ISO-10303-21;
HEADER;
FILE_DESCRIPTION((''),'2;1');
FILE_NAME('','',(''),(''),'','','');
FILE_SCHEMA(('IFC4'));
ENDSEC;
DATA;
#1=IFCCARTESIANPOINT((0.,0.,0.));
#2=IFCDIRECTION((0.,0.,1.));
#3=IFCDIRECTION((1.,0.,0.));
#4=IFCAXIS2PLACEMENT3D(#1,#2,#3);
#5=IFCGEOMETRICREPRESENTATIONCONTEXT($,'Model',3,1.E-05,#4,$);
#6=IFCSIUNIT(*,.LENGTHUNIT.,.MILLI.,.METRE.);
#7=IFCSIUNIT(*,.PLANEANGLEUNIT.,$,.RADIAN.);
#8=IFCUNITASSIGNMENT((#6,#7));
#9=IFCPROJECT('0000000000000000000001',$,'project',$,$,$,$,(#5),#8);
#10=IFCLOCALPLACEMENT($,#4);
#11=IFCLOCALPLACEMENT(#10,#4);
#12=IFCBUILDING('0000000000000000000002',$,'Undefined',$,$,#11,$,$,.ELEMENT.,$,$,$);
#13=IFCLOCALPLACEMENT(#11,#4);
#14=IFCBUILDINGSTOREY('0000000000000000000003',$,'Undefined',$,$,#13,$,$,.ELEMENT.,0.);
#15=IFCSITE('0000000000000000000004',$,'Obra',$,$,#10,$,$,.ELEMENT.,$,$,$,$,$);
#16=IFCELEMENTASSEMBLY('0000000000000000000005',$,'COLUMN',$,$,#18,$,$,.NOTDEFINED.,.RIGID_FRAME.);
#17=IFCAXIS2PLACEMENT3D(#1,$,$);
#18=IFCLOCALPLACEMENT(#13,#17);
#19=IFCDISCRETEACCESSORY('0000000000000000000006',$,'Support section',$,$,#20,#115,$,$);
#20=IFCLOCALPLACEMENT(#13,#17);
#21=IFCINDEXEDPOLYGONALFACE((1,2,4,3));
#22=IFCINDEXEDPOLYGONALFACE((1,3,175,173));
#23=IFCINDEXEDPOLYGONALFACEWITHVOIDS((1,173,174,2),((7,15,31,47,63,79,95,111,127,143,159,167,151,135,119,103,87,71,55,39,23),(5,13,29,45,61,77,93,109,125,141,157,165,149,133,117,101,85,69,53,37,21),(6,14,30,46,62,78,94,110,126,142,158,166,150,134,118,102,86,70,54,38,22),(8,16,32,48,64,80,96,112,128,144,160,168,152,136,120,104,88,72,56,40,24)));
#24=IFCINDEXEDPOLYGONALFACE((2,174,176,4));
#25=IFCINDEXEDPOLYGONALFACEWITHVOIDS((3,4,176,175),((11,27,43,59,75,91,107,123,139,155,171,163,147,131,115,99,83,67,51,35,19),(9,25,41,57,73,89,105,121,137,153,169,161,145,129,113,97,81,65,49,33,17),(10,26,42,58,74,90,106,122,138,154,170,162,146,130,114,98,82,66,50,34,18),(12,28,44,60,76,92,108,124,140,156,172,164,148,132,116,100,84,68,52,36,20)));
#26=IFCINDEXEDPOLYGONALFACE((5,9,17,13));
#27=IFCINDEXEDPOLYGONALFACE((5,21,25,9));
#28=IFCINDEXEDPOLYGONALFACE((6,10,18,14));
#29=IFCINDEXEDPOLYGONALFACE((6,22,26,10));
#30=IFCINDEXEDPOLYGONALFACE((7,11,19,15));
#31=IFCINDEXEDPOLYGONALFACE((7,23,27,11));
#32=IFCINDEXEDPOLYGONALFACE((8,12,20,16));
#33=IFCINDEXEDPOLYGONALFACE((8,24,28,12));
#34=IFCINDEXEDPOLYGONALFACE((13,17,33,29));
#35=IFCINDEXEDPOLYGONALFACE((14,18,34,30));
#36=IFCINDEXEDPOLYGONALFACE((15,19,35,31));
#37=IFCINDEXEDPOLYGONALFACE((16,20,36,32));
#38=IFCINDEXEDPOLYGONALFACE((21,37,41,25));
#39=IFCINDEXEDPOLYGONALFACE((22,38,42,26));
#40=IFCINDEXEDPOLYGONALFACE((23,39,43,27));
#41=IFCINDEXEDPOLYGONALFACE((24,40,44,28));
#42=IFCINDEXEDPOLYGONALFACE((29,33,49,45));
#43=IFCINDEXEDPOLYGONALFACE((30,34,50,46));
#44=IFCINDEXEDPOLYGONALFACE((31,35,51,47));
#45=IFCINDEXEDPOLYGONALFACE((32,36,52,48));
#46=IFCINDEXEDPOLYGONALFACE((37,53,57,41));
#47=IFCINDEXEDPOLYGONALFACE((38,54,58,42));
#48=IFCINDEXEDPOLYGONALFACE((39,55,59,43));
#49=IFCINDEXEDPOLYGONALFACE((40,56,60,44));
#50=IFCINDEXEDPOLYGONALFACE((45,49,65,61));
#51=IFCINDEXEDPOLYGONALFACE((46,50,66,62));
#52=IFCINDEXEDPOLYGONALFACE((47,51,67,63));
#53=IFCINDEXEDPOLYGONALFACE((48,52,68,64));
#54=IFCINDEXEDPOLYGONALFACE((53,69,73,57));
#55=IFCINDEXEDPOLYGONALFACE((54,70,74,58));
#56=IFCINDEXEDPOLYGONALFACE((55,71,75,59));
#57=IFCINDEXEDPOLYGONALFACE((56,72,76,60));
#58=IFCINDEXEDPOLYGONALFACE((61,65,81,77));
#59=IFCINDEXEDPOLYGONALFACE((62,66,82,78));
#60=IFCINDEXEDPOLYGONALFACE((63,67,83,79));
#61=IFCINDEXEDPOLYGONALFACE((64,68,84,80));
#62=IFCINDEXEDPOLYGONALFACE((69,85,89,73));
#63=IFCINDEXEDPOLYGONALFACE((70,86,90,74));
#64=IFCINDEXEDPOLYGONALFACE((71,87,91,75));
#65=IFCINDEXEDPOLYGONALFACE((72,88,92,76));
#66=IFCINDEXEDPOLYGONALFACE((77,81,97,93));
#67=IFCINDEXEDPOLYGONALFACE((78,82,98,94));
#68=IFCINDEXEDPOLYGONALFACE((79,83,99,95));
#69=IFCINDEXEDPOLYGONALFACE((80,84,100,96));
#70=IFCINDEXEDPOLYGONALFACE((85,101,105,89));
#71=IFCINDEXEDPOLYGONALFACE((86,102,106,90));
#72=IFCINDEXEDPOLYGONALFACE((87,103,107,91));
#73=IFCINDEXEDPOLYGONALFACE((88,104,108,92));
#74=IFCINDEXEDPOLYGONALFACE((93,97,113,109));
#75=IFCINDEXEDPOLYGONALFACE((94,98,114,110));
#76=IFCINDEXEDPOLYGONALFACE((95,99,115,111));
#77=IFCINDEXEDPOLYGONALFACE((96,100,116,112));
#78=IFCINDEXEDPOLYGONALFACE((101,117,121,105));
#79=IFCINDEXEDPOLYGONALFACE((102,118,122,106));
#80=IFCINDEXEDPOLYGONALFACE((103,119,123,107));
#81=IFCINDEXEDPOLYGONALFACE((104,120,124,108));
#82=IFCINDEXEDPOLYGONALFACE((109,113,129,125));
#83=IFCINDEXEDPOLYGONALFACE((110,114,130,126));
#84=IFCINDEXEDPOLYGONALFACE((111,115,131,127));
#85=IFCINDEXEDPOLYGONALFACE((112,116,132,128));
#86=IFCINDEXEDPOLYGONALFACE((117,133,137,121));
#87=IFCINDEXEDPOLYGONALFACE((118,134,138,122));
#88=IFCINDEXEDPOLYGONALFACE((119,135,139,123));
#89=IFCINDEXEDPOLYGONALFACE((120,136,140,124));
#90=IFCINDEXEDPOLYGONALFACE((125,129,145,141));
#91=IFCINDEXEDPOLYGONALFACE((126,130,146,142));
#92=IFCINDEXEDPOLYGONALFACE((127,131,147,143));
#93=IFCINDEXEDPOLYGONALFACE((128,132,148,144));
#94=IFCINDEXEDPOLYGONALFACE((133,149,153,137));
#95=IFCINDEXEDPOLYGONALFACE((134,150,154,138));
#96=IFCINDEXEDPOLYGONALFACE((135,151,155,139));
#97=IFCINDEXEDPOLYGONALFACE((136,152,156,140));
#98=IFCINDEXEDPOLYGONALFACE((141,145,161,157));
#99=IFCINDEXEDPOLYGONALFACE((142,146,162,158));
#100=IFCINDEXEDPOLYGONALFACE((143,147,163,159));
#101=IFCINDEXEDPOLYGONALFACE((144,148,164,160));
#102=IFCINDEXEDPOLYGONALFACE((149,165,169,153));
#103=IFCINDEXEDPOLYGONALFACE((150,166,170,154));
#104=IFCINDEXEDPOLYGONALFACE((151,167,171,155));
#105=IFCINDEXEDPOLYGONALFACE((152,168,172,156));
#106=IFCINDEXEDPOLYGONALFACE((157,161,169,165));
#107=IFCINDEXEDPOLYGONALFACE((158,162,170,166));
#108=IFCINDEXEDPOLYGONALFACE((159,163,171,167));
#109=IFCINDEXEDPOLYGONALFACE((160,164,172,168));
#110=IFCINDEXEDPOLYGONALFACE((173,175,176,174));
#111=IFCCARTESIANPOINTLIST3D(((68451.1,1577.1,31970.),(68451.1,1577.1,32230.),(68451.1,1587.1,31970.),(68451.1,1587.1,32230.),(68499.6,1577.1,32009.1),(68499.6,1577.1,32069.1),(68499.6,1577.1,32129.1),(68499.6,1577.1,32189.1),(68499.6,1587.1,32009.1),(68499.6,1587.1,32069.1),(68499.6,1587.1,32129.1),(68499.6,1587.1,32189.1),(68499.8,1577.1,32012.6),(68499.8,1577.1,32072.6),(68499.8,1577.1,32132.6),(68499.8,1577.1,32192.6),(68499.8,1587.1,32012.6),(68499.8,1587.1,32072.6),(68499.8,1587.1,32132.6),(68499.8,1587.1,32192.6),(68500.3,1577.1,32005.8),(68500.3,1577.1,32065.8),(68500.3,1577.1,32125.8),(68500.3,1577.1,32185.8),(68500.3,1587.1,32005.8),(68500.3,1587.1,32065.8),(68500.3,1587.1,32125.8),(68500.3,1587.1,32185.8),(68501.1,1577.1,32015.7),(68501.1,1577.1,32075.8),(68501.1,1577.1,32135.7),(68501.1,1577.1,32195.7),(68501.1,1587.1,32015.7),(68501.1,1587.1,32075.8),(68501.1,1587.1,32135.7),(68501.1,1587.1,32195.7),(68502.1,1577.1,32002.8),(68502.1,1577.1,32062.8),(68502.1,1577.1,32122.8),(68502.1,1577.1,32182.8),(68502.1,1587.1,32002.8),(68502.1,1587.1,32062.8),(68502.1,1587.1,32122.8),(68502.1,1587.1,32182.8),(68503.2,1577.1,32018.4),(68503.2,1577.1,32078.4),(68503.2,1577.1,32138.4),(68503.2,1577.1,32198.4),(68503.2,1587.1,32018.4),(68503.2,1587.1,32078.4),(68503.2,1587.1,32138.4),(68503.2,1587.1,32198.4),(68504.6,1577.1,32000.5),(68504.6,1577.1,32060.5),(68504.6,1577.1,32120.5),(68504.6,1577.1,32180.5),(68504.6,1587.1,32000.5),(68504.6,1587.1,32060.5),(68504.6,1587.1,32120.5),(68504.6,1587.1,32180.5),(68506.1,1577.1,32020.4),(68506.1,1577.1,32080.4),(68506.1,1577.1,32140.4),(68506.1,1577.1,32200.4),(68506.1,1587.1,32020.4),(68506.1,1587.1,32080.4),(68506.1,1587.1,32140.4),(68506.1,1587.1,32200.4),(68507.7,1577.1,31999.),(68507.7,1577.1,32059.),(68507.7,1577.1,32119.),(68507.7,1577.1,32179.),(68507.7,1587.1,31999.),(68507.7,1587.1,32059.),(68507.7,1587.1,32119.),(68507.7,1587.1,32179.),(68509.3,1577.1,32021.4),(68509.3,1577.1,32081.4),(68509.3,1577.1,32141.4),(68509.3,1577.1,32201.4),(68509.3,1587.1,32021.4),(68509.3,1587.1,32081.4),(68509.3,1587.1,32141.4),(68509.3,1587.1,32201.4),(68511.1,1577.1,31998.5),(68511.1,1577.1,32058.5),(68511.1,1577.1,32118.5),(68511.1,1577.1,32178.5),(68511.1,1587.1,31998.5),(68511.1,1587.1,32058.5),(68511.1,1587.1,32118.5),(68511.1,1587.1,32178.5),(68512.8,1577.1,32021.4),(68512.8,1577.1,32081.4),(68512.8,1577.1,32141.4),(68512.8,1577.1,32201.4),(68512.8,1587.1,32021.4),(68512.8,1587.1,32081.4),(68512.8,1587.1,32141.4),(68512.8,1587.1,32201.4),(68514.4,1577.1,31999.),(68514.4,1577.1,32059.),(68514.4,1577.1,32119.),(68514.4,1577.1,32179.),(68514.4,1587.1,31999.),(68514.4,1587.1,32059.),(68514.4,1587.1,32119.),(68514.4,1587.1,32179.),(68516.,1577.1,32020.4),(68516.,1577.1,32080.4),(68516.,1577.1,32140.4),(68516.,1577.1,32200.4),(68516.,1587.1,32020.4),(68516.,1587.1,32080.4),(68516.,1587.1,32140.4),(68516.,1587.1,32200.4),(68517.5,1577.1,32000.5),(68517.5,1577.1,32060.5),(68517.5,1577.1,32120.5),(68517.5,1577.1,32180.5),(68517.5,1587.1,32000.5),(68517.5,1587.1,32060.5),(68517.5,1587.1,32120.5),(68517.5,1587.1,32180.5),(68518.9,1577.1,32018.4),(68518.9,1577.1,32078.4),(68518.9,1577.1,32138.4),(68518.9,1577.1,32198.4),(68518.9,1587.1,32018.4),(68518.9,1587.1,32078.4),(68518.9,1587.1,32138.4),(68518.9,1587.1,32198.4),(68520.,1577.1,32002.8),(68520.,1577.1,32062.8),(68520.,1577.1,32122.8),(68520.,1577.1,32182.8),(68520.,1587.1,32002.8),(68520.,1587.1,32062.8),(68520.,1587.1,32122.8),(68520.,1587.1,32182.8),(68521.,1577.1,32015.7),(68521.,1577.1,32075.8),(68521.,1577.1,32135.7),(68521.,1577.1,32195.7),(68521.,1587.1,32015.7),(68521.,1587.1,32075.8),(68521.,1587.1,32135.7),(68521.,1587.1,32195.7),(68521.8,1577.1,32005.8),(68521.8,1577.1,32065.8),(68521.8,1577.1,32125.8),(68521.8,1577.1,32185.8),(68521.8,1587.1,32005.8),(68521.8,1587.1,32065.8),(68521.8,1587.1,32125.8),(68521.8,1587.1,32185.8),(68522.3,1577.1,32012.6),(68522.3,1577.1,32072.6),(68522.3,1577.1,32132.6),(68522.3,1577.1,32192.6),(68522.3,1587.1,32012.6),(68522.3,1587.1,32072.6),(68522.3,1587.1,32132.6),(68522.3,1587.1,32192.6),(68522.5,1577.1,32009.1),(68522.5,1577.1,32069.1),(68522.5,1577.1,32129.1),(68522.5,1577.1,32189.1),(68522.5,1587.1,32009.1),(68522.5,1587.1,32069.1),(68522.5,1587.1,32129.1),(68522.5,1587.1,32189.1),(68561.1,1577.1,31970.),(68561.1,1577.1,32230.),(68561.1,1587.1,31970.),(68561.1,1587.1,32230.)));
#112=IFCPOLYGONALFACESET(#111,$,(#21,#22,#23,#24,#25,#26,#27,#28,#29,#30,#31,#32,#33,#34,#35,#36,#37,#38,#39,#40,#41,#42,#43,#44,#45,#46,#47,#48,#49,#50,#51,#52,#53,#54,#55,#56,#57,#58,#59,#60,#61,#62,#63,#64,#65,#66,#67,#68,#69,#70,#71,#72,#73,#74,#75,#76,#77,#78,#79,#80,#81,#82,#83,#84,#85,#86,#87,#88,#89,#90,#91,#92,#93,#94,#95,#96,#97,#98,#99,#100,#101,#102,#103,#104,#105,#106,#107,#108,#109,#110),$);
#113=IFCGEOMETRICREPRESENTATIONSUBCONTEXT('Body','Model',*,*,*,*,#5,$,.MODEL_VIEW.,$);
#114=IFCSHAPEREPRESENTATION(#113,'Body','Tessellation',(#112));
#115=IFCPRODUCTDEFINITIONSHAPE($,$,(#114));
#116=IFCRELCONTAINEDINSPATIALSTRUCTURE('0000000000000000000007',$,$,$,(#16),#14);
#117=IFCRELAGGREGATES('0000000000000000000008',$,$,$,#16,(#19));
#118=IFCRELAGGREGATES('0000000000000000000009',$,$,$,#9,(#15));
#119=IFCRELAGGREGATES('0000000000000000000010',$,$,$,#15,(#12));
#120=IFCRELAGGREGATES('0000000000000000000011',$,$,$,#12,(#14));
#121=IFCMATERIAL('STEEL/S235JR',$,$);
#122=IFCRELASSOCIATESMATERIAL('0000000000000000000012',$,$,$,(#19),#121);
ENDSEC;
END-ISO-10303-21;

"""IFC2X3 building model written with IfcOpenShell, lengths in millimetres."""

from ifc_helpers import new_model, si_unit, frame, origin_with_axes, origin_2d_with_axis, place, context, subcontext, project, spatial, rectangle, circle, extrude, source, transform, mapped, material, element, aggregate, save


model = new_model("IFC2X3")

# Units and contexts
model_context = context("Model", 3, precision=1e-05, world=origin_with_axes())
body_context = subcontext(model_context, "Body", "Model", "MODEL_VIEW")
ifc_project = project(units=[si_unit("LENGTHUNIT", "METRE", prefix="MILLI"), si_unit("PLANEANGLEUNIT", "RADIAN")], contexts=[model_context])

# Site, building, storey
site_placement = place(None, origin_with_axes())
site = spatial("IfcSite", under=ifc_project, at=site_placement, Name="Obra", CompositionType="ELEMENT")
building_placement = place(site_placement, origin_with_axes())
building = spatial("IfcBuilding", under=site, at=building_placement, Name="Undefined", CompositionType="ELEMENT")
storey_placement = place(building_placement, origin_with_axes())
storey = spatial("IfcBuildingStorey", under=building, at=storey_placement, Name="Undefined", CompositionType="ELEMENT", Elevation=0.0)

# Element assembly
assembly_1_placement = place(storey_placement, origin_with_axes())
assembly_1 = element("IfcElementAssembly", 1, at=assembly_1_placement, inside=storey, Name="COLUMN", AssemblyPlace="NOTDEFINED", PredefinedType="RIGID_FRAME")
ifc_material_1 = material(Name="STEEL/S235JR")

# Shared definitions
shared_shape_1 = source(origin_with_axes(), body_context, "Body", "SweptSolid", [
    extrude(circle(Radius=11.5, at=origin_2d_with_axis()), frame((0.0, -14.4, 0.0), z_axis=(0.0, 1.0, 0.0), x_axis=(1.0, 0.0, 0.0)), (0.0, 0.0, 1.0), 10.2),
])

# Discrete accessory, opening
discrete_accessory_1_placement = place(assembly_1_placement, frame((68506.1, 1582.1, 31970.0), z_axis=(0.0, 0.0, 1.0), x_axis=(-1.0, 0.0, 0.0)))
discrete_accessory_1 = element("IfcDiscreteAccessory", 2, at=discrete_accessory_1_placement, material=ifc_material_1, Name="Support section", context=body_context, shape_type="SweptSolid", body=[
    extrude(rectangle(XDim=10.0, YDim=110.0, at=origin_2d_with_axis()), frame((0.0, 0.0, 260.0), z_axis=(0.0, 0.0, -1.0), x_axis=(0.0, 1.0, 0.0)), (0.0, 0.0, 1.0), 260.0),
])
opening_1_placement = place(assembly_1_placement, frame((68461.1, 1591.4, 32300.0), z_axis=(1.0, 0.0, 0.0), x_axis=(0.0, 0.0, -1.0)))
element("IfcOpeningElement", 3, at=opening_1_placement, cuts=discrete_accessory_1, ObjectType="Opening", context=body_context, shape_type="MappedRepresentation", body=[
    mapped(shared_shape_1, transform((110.0, 0.0, 50.0))),
    mapped(shared_shape_1, transform((170.0, 0.0, 50.0))),
    mapped(shared_shape_1, transform((230.0, 0.0, 50.0))),
    mapped(shared_shape_1, transform((290.0, 0.0, 50.0))),
])
aggregate(assembly_1, [discrete_accessory_1])

save(model, "model.ifc")
